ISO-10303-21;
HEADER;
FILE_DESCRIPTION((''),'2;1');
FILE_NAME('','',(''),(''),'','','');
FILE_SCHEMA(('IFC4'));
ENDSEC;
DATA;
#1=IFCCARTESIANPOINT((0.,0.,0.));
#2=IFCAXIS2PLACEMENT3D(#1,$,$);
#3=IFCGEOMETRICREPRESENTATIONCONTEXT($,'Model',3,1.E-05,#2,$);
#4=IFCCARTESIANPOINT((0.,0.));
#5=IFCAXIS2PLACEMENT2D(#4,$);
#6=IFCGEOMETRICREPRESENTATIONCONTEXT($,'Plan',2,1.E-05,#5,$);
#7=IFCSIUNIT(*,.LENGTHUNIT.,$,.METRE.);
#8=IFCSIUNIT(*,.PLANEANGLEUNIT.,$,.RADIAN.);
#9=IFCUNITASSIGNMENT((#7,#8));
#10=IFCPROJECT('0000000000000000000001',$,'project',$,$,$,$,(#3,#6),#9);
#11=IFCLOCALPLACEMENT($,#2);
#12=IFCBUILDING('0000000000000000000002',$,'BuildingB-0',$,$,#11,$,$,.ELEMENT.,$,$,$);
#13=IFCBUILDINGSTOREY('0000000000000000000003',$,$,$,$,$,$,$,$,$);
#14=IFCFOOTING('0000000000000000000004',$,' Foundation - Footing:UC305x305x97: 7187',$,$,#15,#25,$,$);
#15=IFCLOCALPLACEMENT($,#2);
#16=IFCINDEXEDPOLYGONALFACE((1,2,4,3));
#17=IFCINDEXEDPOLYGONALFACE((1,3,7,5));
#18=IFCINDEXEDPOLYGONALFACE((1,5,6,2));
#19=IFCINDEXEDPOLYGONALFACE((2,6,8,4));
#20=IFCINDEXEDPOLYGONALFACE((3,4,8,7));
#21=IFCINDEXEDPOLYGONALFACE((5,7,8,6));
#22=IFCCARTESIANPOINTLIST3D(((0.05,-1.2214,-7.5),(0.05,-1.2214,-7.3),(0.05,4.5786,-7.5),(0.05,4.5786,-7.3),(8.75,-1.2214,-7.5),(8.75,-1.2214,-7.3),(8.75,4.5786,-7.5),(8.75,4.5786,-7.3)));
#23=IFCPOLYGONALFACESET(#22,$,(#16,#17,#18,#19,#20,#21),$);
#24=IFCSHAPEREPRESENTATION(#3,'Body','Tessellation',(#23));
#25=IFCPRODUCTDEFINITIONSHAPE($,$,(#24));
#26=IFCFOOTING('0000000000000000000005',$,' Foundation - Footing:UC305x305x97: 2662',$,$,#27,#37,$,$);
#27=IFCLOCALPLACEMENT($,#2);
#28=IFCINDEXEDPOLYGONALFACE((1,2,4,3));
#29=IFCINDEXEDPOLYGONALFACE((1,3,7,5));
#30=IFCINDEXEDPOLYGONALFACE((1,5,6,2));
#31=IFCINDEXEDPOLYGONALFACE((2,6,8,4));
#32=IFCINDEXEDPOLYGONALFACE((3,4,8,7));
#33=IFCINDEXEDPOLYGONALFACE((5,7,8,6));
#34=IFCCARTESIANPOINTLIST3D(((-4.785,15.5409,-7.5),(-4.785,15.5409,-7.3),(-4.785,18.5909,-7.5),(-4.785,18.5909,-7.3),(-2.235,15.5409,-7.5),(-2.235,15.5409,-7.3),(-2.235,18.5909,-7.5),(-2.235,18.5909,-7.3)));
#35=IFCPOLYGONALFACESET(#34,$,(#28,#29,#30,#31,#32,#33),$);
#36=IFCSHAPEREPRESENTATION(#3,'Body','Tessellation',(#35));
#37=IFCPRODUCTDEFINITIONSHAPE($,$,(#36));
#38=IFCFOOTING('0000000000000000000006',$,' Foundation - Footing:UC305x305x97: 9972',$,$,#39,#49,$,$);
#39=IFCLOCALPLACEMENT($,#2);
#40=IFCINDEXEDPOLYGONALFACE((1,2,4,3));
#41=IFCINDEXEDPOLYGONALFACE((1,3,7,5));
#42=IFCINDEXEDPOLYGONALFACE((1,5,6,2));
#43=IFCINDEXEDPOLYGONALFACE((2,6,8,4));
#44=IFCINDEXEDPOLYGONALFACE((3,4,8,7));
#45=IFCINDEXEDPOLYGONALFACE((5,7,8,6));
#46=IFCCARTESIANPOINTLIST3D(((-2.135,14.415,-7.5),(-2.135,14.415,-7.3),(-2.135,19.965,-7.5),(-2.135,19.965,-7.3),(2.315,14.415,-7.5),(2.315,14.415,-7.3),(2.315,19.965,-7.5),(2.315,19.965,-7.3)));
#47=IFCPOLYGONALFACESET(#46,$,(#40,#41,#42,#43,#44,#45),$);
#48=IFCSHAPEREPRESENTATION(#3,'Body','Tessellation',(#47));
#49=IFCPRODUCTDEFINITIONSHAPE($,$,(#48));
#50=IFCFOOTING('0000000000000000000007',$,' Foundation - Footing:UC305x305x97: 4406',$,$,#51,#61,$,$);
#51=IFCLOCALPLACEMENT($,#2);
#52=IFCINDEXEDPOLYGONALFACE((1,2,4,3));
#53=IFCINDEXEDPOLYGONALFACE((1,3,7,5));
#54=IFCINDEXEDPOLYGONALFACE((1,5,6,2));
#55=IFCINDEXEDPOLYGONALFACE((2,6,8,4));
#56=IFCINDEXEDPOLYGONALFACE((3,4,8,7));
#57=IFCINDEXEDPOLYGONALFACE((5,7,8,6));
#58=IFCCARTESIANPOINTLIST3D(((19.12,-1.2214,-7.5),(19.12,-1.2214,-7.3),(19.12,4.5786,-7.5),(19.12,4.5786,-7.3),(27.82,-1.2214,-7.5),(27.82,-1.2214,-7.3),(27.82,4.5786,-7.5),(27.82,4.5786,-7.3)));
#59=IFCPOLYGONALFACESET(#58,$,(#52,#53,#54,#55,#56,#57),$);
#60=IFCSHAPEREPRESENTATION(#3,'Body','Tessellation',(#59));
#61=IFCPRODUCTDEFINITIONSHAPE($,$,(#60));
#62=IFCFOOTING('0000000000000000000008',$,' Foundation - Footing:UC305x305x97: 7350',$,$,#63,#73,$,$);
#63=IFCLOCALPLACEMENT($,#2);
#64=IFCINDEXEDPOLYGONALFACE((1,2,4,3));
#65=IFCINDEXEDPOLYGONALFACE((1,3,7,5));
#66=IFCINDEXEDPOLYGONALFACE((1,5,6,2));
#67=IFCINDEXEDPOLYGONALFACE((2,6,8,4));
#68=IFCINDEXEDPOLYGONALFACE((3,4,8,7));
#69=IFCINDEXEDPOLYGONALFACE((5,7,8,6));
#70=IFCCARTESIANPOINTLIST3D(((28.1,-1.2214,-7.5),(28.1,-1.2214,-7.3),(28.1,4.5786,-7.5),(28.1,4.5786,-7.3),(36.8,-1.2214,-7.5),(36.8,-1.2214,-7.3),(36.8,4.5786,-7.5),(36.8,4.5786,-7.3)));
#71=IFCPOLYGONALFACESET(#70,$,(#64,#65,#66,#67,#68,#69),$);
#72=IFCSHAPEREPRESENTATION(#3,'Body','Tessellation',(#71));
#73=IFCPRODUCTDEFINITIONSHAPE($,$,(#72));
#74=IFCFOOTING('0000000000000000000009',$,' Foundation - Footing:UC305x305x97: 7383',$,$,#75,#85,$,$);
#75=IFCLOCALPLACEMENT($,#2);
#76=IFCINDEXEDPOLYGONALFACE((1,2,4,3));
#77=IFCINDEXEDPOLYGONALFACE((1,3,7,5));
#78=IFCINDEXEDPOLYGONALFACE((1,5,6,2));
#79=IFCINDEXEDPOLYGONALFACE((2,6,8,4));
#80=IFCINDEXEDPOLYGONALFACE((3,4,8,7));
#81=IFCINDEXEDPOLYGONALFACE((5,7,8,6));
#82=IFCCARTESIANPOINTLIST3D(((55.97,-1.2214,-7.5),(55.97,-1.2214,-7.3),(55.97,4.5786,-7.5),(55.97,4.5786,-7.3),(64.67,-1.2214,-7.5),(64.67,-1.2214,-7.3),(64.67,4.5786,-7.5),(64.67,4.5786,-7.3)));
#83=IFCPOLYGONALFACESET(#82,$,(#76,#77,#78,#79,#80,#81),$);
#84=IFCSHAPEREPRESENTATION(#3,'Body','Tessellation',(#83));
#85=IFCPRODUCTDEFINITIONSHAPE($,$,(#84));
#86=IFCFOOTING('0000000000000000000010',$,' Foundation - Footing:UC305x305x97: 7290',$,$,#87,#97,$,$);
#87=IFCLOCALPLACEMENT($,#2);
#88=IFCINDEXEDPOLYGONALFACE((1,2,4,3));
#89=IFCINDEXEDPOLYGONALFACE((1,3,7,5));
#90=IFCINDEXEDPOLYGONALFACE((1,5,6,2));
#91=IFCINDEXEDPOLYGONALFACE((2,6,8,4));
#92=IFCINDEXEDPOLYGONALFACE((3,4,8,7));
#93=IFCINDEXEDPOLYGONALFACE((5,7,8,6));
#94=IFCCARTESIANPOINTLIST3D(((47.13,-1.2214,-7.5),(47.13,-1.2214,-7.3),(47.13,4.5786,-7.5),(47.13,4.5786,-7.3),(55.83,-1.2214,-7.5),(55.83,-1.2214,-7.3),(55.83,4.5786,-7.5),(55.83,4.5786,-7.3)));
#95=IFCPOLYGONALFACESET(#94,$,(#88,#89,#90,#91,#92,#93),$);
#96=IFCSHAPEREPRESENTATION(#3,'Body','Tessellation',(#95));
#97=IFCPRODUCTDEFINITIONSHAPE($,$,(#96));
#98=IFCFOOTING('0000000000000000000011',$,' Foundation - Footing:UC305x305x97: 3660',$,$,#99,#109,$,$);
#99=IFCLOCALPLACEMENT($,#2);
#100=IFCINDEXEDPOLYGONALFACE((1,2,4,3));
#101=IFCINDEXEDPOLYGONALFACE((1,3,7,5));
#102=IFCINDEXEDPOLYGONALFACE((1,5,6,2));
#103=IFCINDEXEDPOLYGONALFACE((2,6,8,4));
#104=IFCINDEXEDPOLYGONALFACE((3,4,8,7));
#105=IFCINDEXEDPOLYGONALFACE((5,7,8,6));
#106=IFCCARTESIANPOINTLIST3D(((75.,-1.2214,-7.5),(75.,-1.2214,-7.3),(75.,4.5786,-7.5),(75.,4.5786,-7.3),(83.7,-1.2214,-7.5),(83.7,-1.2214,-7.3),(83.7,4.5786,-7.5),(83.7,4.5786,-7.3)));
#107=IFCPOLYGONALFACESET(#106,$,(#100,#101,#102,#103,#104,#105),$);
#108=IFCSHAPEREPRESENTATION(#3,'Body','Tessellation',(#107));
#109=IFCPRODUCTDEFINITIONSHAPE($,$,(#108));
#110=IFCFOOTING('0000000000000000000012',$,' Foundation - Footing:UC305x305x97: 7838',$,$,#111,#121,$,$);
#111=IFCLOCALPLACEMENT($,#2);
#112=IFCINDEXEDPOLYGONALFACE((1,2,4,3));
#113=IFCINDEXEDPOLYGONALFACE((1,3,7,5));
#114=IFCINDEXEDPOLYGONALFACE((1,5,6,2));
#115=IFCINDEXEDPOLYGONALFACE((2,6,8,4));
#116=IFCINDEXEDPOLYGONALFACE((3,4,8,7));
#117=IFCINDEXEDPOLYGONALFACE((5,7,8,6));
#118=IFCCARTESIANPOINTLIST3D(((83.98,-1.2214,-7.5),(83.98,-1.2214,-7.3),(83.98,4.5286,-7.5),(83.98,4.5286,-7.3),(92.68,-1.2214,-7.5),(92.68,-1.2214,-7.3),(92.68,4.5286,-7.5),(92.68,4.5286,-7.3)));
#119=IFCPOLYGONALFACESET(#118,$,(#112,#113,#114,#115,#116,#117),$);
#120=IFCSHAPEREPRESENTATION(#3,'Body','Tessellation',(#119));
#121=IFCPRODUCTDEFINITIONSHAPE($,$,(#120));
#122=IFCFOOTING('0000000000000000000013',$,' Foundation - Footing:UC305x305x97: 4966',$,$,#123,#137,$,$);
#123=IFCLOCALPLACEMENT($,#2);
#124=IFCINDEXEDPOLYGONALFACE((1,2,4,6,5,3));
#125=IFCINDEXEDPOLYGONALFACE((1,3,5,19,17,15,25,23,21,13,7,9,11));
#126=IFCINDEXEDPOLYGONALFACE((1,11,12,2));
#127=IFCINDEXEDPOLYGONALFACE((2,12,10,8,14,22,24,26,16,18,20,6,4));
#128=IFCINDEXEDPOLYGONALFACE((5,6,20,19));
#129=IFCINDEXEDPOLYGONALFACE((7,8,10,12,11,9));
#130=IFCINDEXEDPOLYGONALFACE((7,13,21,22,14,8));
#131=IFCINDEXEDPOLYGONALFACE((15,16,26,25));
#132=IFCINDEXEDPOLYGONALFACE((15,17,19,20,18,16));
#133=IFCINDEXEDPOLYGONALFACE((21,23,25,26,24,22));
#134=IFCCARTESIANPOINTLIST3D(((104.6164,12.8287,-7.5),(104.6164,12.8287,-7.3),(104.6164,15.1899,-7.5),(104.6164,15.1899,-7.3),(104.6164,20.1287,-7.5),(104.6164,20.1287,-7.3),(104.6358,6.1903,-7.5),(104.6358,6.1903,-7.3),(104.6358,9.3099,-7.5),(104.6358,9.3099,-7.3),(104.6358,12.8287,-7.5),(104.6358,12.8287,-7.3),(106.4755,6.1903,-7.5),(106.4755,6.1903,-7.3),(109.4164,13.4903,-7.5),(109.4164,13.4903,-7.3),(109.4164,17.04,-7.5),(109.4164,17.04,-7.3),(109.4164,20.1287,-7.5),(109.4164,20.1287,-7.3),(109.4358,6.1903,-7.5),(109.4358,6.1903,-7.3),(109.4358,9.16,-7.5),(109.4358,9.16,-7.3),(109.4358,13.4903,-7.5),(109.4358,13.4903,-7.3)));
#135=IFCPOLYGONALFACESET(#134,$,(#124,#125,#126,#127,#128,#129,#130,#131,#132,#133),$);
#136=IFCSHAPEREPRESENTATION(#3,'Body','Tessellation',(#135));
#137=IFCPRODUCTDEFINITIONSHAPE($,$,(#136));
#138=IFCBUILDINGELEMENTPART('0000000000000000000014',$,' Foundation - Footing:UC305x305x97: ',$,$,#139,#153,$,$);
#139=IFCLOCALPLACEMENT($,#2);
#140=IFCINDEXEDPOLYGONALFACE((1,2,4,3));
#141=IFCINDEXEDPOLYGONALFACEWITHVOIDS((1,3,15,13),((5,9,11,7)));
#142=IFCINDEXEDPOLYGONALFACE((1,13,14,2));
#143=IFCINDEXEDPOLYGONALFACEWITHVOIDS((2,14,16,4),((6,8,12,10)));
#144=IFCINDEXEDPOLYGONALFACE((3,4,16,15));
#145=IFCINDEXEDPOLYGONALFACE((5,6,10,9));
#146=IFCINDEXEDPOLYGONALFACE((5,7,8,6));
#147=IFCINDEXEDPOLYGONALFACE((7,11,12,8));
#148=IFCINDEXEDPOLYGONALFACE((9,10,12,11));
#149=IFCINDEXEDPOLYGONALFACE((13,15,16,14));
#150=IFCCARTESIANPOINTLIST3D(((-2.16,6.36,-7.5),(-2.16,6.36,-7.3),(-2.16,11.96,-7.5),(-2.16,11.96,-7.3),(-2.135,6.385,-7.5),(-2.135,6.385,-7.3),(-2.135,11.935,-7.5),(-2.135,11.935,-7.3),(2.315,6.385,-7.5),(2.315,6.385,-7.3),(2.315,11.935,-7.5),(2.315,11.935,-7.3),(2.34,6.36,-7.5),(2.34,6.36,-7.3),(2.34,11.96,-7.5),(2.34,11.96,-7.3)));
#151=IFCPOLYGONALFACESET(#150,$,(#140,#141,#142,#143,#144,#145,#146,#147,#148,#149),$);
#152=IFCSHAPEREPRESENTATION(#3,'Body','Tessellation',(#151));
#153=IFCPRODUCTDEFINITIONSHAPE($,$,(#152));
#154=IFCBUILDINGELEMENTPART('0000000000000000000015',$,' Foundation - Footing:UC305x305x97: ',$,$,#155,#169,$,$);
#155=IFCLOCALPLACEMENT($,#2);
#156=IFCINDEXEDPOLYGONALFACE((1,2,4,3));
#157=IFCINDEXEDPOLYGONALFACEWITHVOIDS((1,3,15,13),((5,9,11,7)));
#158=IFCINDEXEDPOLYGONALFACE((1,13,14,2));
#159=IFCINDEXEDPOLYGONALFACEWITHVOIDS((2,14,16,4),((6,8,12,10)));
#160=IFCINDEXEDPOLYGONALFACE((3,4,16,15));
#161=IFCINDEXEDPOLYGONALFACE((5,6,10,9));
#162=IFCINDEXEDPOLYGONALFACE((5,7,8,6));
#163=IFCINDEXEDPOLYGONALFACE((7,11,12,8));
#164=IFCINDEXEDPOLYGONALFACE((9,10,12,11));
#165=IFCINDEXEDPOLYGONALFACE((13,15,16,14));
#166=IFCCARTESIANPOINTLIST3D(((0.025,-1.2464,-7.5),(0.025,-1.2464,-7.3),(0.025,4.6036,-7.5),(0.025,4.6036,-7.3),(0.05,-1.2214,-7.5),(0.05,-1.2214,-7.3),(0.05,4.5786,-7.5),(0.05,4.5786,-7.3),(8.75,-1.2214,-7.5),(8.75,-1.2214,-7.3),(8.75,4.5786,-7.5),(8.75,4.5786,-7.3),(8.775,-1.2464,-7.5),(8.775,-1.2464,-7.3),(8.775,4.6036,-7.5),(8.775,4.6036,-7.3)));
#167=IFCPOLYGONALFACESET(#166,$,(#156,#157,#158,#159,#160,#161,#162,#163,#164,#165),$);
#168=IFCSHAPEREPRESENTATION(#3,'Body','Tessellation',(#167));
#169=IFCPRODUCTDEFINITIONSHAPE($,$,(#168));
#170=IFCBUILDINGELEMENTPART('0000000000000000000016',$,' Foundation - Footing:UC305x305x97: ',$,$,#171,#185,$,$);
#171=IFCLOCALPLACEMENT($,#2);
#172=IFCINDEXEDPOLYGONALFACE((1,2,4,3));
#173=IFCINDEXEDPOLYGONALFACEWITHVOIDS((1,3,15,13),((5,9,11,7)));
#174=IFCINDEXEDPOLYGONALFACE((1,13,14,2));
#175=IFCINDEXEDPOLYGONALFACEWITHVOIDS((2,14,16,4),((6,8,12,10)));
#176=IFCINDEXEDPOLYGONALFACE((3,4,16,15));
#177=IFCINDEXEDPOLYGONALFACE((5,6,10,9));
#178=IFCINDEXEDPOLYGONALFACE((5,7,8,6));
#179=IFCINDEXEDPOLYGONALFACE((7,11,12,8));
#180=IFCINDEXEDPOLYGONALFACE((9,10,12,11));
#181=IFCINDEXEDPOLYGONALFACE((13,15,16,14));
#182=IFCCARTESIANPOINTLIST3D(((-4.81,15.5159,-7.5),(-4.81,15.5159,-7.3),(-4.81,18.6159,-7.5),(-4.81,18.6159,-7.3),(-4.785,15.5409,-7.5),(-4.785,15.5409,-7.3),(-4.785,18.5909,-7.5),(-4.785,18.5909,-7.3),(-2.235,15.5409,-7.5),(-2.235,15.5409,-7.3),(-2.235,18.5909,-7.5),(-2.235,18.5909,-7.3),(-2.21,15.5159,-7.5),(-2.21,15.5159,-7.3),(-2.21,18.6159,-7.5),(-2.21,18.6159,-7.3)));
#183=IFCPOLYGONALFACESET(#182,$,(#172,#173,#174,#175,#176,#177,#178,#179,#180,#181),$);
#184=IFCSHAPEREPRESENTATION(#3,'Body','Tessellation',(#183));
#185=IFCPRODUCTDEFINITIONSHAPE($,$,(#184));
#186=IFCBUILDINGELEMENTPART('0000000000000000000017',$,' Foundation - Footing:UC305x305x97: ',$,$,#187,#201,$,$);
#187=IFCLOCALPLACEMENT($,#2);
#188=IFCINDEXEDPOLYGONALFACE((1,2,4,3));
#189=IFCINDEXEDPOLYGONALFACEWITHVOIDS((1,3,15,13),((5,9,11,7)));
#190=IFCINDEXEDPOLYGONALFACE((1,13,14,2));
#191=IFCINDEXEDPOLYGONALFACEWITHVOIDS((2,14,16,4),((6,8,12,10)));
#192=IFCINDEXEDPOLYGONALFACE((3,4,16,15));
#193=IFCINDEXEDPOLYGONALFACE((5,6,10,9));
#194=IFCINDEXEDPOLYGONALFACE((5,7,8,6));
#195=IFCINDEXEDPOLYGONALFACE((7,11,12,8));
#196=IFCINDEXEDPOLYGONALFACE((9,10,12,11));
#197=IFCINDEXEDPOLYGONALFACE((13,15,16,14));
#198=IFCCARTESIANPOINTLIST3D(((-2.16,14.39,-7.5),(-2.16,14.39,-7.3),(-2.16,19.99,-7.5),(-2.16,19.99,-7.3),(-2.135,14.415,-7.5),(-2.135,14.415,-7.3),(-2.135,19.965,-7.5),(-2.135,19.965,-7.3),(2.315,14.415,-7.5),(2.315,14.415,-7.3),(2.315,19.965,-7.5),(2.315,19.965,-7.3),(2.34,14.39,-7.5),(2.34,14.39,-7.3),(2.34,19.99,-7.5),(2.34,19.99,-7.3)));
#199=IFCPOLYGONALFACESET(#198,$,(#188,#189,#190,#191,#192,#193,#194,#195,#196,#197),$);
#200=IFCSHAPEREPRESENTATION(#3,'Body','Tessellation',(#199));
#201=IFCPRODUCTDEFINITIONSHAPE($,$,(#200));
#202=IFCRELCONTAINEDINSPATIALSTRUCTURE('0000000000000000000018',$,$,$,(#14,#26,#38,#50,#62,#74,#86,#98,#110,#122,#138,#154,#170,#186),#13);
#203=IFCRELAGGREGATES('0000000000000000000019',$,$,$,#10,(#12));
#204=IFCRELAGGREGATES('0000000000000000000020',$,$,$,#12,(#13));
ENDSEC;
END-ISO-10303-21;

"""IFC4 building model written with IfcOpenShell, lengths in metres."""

from ifc_helpers import new_model, si_unit, origin, origin_2d, place, context, project, spatial, polyline, outline, extrude, element, save


model = new_model("IFC4")

# Units and contexts
model_context = context("Model", 3, precision=1e-05, world=origin())
plan_context = context("Plan", 2, precision=1e-05, world=origin_2d())
ifc_project = project(units=[si_unit("LENGTHUNIT", "METRE"), si_unit("PLANEANGLEUNIT", "RADIAN")], contexts=[model_context, plan_context])

# Building, storey
building_placement = place(None, origin())
building = spatial("IfcBuilding", under=ifc_project, at=building_placement, Name="BuildingB-0", CompositionType="ELEMENT")
storey = spatial("IfcBuildingStorey", under=building)

# Footings
element("IfcFooting", 1, inside=storey, Name=" Foundation - Footing:UC305x305x97: 7187", context=model_context, shape_type="SweptSolid", body=[
    extrude(outline(polyline([(0.05, -1.2214, -7.5), (8.75, -1.2214, -7.5), (8.75, 4.5786, -7.5), (0.05, 4.5786, -7.5), (0.05, -1.2214, -7.5)])), None, (0.0, 0.0, 1.0), 0.2),
])
element("IfcFooting", 2, inside=storey, Name=" Foundation - Footing:UC305x305x97: 2662", context=model_context, shape_type="SweptSolid", body=[
    extrude(outline(polyline([(-4.785, 15.5409, -7.5), (-2.235, 15.5409, -7.5), (-2.235, 18.5909, -7.5), (-4.785, 18.5909, -7.5), (-4.785, 15.5409, -7.5)])), None, (0.0, 0.0, 1.0), 0.2),
])
element("IfcFooting", 3, inside=storey, Name=" Foundation - Footing:UC305x305x97: 9972", context=model_context, shape_type="SweptSolid", body=[
    extrude(outline(polyline([(-2.135, 14.415, -7.5), (2.315, 14.415, -7.5), (2.315, 19.965, -7.5), (-2.135, 19.965, -7.5), (-2.135, 14.415, -7.5)])), None, (0.0, 0.0, 1.0), 0.2),
])
element("IfcFooting", 4, inside=storey, Name=" Foundation - Footing:UC305x305x97: 4406", context=model_context, shape_type="SweptSolid", body=[
    extrude(outline(polyline([(19.12, -1.2214, -7.5), (27.82, -1.2214, -7.5), (27.82, 4.5786, -7.5), (19.12, 4.5786, -7.5), (19.12, -1.2214, -7.5)])), None, (0.0, 0.0, 1.0), 0.2),
])
element("IfcFooting", 5, inside=storey, Name=" Foundation - Footing:UC305x305x97: 7350", context=model_context, shape_type="SweptSolid", body=[
    extrude(outline(polyline([(28.1, -1.2214, -7.5), (36.8, -1.2214, -7.5), (36.8, 4.5786, -7.5), (28.1, 4.5786, -7.5), (28.1, -1.2214, -7.5)])), None, (0.0, 0.0, 1.0), 0.2),
])
element("IfcFooting", 6, inside=storey, Name=" Foundation - Footing:UC305x305x97: 7383", context=model_context, shape_type="SweptSolid", body=[
    extrude(outline(polyline([(55.97, -1.2214, -7.5), (64.67, -1.2214, -7.5), (64.67, 4.5786, -7.5), (55.97, 4.5786, -7.5), (55.97, -1.2214, -7.5)])), None, (0.0, 0.0, 1.0), 0.2),
])
element("IfcFooting", 7, inside=storey, Name=" Foundation - Footing:UC305x305x97: 7290", context=model_context, shape_type="SweptSolid", body=[
    extrude(outline(polyline([(47.13, -1.2214, -7.5), (55.83, -1.2214, -7.5), (55.83, 4.5786, -7.5), (47.13, 4.5786, -7.5), (47.13, -1.2214, -7.5)])), None, (0.0, 0.0, 1.0), 0.2),
])
element("IfcFooting", 8, inside=storey, Name=" Foundation - Footing:UC305x305x97: 3660", context=model_context, shape_type="SweptSolid", body=[
    extrude(outline(polyline([(75.0, -1.2214, -7.5), (83.7, -1.2214, -7.5), (83.7, 4.5786, -7.5), (75.0, 4.5786, -7.5), (75.0, -1.2214, -7.5)])), None, (0.0, 0.0, 1.0), 0.2),
])
element("IfcFooting", 9, inside=storey, Name=" Foundation - Footing:UC305x305x97: 7838", context=model_context, shape_type="SweptSolid", body=[
    extrude(outline(polyline([(92.68, -1.2214, -7.5), (83.98, -1.2214, -7.5), (83.98, 4.5286, -7.5), (92.68, 4.5286, -7.5), (92.68, -1.2214, -7.5)])), None, (0.0, 0.0, 1.0), 0.2),
])
element("IfcFooting", 10, inside=storey, Name=" Foundation - Footing:UC305x305x97: 4966", context=model_context, shape_type="SweptSolid", body=[
    extrude(outline(polyline([(104.6358, 12.8287, -7.5), (104.6164, 12.8287, -7.5), (104.6164, 15.1899, -7.5), (104.6164, 20.1287, -7.5), (109.4164, 20.1287, -7.5), (109.4164, 17.04, -7.5), (109.4164, 13.4903, -7.5), (109.4358, 13.4903, -7.5), (109.4358, 9.16, -7.5), (109.4358, 6.1903, -7.5), (106.4755, 6.1903, -7.5), (104.6358, 6.1903, -7.5), (104.6358, 9.3099, -7.5), (104.6358, 12.8287, -7.5)])), None, (0.0, 0.0, 1.0), 0.2),
])

# Building element parts, openings
building_element_part_1 = element("IfcBuildingElementPart", 11, inside=storey, Name=" Foundation - Footing:UC305x305x97: ", context=model_context, shape_type="SweptSolid", body=[
    extrude(outline(polyline([(-2.16, 6.36, -7.5), (2.34, 6.36, -7.5), (2.34, 11.96, -7.5), (-2.16, 11.96, -7.5), (-2.16, 6.36, -7.5)])), None, (0.0, 0.0, 1.0), 0.2),
])
element("IfcOpeningElement", 12, inside=storey, cuts=building_element_part_1, context=model_context, shape_type="SweptSolid", body=[
    extrude(outline(polyline([(-2.135, 6.385, -7.5), (2.315, 6.385, -7.5), (2.315, 11.935, -7.5), (-2.135, 11.935, -7.5), (-2.135, 6.385, -7.5)])), None, (0.0, 0.0, 1.0), 0.2),
])
building_element_part_2 = element("IfcBuildingElementPart", 13, inside=storey, Name=" Foundation - Footing:UC305x305x97: ", context=model_context, shape_type="SweptSolid", body=[
    extrude(outline(polyline([(0.025, -1.2464, -7.5), (8.775, -1.2464, -7.5), (8.775, 4.6036, -7.5), (0.025, 4.6036, -7.5), (0.025, -1.2464, -7.5)])), None, (0.0, 0.0, 1.0), 0.2),
])
element("IfcOpeningElement", 14, inside=storey, cuts=building_element_part_2, context=model_context, shape_type="SweptSolid", body=[
    extrude(outline(polyline([(0.05, -1.2214, -7.5), (8.75, -1.2214, -7.5), (8.75, 4.5786, -7.5), (0.05, 4.5786, -7.5), (0.05, -1.2214, -7.5)])), None, (0.0, 0.0, 1.0), 0.2),
])
building_element_part_3 = element("IfcBuildingElementPart", 15, inside=storey, Name=" Foundation - Footing:UC305x305x97: ", context=model_context, shape_type="SweptSolid", body=[
    extrude(outline(polyline([(-4.81, 15.5159, -7.5), (-2.21, 15.5159, -7.5), (-2.21, 18.6159, -7.5), (-4.81, 18.6159, -7.5), (-4.81, 15.5159, -7.5)])), None, (0.0, 0.0, 1.0), 0.2),
])
element("IfcOpeningElement", 16, inside=storey, cuts=building_element_part_3, context=model_context, shape_type="SweptSolid", body=[
    extrude(outline(polyline([(-4.785, 15.5409, -7.5), (-2.235, 15.5409, -7.5), (-2.235, 18.5909, -7.5), (-4.785, 18.5909, -7.5), (-4.785, 15.5409, -7.5)])), None, (0.0, 0.0, 1.0), 0.2),
])
building_element_part_4 = element("IfcBuildingElementPart", 17, inside=storey, Name=" Foundation - Footing:UC305x305x97: ", context=model_context, shape_type="SweptSolid", body=[
    extrude(outline(polyline([(-2.16, 14.39, -7.5), (2.34, 14.39, -7.5), (2.34, 19.99, -7.5), (-2.16, 19.99, -7.5), (-2.16, 14.39, -7.5)])), None, (0.0, 0.0, 1.0), 0.2),
])
element("IfcOpeningElement", 18, inside=storey, cuts=building_element_part_4, context=model_context, shape_type="SweptSolid", body=[
    extrude(outline(polyline([(-2.135, 14.415, -7.5), (2.315, 14.415, -7.5), (2.315, 19.965, -7.5), (-2.135, 19.965, -7.5), (-2.135, 14.415, -7.5)])), None, (0.0, 0.0, 1.0), 0.2),
])

save(model, "model.ifc")
